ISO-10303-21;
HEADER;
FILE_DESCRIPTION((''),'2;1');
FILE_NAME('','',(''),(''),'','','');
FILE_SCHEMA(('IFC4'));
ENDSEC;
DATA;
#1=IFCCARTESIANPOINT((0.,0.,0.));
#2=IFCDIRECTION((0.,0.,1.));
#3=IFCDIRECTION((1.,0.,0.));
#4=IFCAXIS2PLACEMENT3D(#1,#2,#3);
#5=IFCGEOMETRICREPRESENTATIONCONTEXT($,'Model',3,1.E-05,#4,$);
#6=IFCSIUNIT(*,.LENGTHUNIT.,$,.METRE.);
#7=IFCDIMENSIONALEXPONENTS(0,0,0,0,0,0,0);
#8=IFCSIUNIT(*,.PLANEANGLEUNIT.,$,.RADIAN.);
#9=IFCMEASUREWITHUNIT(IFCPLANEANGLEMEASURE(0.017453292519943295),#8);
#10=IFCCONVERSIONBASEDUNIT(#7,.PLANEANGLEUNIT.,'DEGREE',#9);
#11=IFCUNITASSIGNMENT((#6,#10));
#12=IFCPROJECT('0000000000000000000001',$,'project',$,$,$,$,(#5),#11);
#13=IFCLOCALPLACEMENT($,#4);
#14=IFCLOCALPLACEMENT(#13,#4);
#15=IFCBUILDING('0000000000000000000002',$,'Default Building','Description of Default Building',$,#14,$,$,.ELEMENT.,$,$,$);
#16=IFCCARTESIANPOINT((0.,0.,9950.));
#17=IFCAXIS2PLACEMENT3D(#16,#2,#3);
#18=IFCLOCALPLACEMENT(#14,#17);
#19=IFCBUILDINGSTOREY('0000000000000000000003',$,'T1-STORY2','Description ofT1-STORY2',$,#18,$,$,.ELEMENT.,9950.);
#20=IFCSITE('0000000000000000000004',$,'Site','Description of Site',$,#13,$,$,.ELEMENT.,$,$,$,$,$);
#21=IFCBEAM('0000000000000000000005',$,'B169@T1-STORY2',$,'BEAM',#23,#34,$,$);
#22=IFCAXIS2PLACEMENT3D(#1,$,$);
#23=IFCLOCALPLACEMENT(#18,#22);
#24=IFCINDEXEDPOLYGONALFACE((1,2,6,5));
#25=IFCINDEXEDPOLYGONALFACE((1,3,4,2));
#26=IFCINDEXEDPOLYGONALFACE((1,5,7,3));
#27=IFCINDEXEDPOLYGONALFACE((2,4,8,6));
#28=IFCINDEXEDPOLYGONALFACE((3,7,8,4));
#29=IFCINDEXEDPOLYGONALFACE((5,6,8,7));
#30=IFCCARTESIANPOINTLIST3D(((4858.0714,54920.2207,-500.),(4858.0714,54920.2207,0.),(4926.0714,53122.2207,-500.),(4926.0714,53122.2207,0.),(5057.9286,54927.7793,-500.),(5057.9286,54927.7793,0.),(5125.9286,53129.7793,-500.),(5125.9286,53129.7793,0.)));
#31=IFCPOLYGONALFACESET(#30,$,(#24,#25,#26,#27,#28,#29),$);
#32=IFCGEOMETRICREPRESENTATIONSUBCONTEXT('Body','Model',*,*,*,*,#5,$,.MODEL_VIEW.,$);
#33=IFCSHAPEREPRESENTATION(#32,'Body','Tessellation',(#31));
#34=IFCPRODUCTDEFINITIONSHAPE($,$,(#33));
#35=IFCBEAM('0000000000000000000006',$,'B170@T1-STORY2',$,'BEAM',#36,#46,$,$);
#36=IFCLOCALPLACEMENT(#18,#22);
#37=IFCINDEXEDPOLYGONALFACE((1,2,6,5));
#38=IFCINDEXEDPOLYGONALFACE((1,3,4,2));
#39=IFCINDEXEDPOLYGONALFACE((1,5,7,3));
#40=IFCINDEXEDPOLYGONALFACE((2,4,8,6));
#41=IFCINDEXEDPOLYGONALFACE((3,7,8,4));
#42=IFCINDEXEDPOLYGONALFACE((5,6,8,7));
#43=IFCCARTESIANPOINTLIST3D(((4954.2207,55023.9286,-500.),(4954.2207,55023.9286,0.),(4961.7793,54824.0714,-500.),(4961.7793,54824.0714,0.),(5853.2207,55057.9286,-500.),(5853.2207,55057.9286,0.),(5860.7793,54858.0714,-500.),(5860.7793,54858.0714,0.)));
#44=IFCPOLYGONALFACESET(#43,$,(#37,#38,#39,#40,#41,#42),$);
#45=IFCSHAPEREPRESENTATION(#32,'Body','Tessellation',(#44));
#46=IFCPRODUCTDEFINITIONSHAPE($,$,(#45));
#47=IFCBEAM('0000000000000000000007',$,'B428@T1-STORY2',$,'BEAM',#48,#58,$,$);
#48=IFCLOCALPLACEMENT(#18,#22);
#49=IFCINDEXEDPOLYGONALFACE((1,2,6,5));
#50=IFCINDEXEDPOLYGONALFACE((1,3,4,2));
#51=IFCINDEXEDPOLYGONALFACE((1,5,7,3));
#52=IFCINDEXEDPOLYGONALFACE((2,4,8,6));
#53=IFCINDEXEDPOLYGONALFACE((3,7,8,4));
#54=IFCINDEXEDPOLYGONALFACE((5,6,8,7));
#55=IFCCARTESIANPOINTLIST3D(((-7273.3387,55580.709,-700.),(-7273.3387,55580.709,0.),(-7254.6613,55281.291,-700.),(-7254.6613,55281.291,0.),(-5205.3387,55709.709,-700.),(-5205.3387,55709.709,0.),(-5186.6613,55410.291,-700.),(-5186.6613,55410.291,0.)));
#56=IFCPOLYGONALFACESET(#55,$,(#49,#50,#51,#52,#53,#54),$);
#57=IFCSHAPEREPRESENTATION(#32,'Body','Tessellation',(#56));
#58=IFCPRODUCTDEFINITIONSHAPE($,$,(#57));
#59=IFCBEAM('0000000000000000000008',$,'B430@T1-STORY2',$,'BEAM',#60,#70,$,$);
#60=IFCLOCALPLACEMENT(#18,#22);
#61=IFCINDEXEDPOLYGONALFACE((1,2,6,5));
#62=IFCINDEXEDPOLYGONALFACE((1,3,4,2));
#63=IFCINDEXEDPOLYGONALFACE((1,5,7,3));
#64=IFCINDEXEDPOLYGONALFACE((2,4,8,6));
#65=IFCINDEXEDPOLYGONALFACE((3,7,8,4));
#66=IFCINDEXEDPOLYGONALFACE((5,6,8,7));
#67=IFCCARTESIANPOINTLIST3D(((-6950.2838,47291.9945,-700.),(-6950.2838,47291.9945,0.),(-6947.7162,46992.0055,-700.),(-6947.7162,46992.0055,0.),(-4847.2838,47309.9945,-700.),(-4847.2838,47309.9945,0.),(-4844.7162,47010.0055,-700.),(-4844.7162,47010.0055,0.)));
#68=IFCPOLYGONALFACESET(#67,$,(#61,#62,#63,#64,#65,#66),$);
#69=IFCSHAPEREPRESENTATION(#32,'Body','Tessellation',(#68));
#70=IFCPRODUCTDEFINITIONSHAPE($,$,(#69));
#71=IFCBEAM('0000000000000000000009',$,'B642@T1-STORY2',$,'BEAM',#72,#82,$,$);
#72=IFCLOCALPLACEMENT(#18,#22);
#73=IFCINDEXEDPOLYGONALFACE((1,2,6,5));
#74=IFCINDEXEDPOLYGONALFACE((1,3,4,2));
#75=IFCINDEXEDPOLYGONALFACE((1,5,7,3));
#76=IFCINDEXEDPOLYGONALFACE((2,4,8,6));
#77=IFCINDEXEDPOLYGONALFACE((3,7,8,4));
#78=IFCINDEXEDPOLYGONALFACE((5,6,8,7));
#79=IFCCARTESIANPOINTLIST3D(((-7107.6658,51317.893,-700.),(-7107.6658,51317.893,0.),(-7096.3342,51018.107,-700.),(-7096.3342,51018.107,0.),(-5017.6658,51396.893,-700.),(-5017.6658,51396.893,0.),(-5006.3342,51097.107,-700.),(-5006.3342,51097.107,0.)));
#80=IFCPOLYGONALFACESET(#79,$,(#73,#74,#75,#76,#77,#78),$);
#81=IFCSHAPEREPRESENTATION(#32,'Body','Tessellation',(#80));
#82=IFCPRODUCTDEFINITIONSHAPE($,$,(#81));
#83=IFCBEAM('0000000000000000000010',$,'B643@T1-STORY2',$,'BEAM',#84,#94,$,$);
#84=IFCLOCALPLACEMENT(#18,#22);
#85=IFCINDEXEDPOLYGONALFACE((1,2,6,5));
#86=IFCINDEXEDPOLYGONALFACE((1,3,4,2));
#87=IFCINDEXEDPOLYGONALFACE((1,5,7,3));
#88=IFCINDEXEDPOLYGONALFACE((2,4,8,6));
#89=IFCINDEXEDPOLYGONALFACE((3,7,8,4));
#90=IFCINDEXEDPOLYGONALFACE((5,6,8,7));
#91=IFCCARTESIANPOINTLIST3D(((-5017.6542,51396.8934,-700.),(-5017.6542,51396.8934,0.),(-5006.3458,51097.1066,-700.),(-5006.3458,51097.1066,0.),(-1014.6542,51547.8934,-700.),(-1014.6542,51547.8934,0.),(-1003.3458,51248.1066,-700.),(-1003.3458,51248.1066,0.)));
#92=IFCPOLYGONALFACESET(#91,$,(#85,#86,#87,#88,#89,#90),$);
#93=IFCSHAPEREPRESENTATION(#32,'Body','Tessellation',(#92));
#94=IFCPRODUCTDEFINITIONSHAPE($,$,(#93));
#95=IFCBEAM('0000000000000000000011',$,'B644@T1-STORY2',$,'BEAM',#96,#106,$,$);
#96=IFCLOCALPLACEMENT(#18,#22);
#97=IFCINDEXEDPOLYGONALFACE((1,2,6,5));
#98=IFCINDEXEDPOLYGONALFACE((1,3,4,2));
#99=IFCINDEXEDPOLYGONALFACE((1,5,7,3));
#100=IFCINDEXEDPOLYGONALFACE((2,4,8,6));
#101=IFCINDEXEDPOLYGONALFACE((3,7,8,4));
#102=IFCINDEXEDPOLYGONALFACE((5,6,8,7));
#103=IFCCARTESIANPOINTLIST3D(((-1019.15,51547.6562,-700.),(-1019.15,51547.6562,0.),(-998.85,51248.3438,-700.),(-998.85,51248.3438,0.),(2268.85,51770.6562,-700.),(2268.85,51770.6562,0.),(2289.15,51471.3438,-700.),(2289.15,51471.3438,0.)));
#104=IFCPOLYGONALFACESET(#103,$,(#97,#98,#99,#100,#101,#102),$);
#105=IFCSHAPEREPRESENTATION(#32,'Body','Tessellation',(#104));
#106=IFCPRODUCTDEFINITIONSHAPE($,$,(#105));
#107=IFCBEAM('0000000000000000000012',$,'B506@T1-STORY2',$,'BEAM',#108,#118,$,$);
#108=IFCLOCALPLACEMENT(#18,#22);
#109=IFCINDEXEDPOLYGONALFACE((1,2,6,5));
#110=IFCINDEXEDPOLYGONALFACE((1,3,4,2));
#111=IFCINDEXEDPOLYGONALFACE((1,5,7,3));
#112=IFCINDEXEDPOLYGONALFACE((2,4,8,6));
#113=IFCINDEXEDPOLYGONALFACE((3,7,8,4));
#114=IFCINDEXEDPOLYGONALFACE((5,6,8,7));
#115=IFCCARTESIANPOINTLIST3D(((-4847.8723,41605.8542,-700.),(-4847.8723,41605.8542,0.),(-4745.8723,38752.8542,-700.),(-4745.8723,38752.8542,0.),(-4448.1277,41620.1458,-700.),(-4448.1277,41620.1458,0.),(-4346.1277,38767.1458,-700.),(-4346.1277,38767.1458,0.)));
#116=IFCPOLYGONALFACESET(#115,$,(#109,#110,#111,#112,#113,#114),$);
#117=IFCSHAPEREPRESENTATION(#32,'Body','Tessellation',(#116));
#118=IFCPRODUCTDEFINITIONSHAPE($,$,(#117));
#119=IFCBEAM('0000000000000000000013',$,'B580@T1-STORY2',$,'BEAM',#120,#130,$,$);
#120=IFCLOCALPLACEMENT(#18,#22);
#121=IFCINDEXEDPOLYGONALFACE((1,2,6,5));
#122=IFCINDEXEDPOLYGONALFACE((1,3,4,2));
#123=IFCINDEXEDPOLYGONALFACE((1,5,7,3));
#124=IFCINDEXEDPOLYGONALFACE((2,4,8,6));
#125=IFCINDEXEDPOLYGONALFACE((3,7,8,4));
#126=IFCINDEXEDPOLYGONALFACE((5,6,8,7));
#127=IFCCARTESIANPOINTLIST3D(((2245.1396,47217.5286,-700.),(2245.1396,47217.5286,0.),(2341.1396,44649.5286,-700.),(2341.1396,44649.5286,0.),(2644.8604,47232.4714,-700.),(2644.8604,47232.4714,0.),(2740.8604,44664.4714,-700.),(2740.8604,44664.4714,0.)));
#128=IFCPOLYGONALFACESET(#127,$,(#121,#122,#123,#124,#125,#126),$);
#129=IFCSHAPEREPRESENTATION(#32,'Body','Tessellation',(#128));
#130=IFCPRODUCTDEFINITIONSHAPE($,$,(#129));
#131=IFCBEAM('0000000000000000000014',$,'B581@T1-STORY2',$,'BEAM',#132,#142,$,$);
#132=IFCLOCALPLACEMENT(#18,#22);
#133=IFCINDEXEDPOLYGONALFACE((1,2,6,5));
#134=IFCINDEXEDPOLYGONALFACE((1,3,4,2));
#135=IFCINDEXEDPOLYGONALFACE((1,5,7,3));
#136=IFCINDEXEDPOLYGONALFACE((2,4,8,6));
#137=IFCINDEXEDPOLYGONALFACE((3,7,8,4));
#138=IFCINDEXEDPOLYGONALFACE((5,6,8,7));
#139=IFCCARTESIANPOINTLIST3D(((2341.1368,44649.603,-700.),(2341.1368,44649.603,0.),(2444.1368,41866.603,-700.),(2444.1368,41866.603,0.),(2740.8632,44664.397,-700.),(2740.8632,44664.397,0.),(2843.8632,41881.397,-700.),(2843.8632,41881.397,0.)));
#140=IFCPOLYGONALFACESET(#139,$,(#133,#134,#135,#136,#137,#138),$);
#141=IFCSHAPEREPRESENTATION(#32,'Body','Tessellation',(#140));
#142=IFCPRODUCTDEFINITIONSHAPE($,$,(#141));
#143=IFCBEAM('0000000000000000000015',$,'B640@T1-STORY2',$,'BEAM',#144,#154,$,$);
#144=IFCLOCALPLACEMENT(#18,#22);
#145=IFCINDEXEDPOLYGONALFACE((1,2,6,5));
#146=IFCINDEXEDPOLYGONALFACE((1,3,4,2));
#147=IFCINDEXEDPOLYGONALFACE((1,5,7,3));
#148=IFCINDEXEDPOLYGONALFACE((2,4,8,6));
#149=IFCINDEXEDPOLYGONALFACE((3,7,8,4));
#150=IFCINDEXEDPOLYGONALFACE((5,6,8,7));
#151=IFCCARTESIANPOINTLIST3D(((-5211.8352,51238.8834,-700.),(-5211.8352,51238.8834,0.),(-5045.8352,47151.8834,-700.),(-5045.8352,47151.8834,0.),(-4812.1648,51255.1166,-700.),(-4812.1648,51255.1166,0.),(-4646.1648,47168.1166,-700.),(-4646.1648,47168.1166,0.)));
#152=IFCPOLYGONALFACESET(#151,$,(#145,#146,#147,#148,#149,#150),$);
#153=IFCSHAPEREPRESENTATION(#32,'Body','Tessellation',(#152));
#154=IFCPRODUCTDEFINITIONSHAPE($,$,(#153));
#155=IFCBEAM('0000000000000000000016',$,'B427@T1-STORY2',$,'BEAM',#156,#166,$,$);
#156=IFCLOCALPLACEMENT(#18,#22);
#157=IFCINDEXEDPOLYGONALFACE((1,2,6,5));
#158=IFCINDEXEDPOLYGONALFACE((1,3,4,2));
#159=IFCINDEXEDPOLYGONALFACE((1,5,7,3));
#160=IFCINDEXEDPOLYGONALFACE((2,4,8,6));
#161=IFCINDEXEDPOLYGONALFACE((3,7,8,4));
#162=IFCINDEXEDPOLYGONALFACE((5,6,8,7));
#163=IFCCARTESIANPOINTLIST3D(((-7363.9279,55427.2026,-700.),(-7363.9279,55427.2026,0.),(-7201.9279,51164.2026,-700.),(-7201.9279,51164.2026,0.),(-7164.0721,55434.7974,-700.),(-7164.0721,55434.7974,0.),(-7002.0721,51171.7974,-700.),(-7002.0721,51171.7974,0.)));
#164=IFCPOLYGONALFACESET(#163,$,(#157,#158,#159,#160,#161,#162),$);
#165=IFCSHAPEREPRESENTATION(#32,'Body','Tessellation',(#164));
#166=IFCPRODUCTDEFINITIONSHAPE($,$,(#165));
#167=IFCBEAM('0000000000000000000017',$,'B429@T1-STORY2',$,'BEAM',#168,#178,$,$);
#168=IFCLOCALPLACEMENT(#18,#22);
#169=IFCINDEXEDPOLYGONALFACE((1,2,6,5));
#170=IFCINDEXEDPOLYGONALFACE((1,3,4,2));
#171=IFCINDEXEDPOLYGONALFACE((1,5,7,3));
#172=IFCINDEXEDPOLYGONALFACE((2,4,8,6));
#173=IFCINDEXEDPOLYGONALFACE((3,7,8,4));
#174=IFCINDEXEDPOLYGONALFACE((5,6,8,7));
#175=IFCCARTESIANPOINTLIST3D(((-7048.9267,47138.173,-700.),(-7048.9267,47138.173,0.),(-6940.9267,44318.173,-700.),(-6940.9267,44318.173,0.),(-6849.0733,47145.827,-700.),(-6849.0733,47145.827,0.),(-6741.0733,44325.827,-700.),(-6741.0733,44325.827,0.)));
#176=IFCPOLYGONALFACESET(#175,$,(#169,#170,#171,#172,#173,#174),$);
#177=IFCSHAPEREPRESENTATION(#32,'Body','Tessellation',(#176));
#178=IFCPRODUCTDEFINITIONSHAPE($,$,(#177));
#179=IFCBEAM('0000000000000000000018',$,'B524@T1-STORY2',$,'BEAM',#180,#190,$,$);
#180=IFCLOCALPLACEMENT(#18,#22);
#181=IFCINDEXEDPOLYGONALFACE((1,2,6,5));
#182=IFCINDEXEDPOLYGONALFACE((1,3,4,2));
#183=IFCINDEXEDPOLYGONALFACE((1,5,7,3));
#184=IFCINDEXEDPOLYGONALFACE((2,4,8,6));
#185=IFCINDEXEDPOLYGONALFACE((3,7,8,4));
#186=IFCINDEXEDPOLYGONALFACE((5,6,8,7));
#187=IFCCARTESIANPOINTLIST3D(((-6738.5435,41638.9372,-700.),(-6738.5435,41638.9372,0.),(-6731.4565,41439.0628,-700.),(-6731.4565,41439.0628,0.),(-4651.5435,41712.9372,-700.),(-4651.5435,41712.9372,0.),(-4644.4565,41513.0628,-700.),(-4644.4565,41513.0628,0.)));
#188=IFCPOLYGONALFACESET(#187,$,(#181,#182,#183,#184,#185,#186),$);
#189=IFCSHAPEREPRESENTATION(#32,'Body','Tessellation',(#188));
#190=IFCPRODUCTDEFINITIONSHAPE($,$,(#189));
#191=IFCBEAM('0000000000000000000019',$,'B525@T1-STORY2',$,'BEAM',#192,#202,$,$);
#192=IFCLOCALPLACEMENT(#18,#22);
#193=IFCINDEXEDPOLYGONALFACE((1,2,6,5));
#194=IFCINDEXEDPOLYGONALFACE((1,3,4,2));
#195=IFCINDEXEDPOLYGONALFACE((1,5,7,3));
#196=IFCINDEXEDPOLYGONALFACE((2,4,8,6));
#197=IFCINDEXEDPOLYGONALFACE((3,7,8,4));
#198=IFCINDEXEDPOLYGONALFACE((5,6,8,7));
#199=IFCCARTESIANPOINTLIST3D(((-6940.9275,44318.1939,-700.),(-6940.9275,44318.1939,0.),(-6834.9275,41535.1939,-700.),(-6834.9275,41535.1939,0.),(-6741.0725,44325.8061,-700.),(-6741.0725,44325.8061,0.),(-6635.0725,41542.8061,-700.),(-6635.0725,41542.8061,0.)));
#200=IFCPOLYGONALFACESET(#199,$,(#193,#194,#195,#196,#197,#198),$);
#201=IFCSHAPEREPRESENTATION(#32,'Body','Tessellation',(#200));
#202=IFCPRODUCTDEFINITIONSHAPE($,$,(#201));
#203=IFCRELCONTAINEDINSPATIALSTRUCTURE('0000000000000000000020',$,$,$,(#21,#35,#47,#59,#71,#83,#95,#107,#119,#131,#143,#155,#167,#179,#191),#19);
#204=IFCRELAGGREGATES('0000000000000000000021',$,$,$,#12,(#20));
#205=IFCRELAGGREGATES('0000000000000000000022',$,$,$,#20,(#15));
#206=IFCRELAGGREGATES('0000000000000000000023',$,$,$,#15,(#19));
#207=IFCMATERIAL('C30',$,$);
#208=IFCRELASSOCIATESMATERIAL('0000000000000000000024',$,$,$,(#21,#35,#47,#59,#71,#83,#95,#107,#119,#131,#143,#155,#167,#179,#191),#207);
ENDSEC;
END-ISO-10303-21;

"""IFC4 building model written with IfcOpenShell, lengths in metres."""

from ifc_helpers import new_model, entity, si_unit, converted_unit, frame, origin_with_axes, place, context, subcontext, project, spatial, rectangle, extrude, material, element, save


model = new_model("IFC4")

# Units and contexts
model_context = context("Model", 3, precision=1e-05, world=origin_with_axes())
body_context = subcontext(model_context, "Body", "Model", "MODEL_VIEW")
ifc_project = project(units=[si_unit("LENGTHUNIT", "METRE"), converted_unit("PLANEANGLEUNIT", "DEGREE", entity("IfcPlaneAngleMeasure", 0.017453292519943295), si_unit("PLANEANGLEUNIT", "RADIAN"), dimensions=[0, 0, 0, 0, 0, 0, 0])], contexts=[model_context])

# Site, building, storey
site_placement = place(None, origin_with_axes())
site = spatial("IfcSite", under=ifc_project, at=site_placement, Name="Site", Description="Description of Site", CompositionType="ELEMENT")
building_placement = place(site_placement, origin_with_axes())
building = spatial("IfcBuilding", under=site, at=building_placement, Name="Default Building", Description="Description of Default Building", CompositionType="ELEMENT")
storey_placement = place(building_placement, frame((0.0, 0.0, 9950.0), z_axis=(0.0, 0.0, 1.0), x_axis=(1.0, 0.0, 0.0)))
storey = spatial("IfcBuildingStorey", under=building, at=storey_placement, Name="T1-STORY2", Description="Description ofT1-STORY2", CompositionType="ELEMENT", Elevation=9950.0)

# Beams
ifc_material_1 = material(Name="C30")
beam_1_placement = place(storey_placement, frame((4958.0, 54924.0, -250.0), z_axis=(0.037793, -0.999286, 0.0), x_axis=(0.999286, 0.037793, 0.0)))
element("IfcBeam", 1, at=beam_1_placement, inside=storey, material=ifc_material_1, Name="B169@T1-STORY2", ObjectType="BEAM", context=body_context, shape_type="SweptSolid", body=[
    extrude(rectangle(XDim=200.0, YDim=500.0), origin_with_axes(), (0.0, 0.0, 1.0), 1799.2854),
])
beam_2_placement = place(storey_placement, frame((4958.0, 54924.0, -250.0), z_axis=(0.999286, 0.037793, 0.0), x_axis=(-0.037793, 0.999286, 0.0)))
element("IfcBeam", 2, at=beam_2_placement, inside=storey, material=ifc_material_1, Name="B170@T1-STORY2", ObjectType="BEAM", context=body_context, shape_type="SweptSolid", body=[
    extrude(rectangle(XDim=200.0, YDim=500.0), origin_with_axes(), (0.0, 0.0, 1.0), 899.6427),
])
beam_3_placement = place(storey_placement, frame((-7264.0, 55431.0, -350.0), z_axis=(0.99806, 0.062258, 0.0), x_axis=(-0.062258, 0.99806, 0.0)))
element("IfcBeam", 3, at=beam_3_placement, inside=storey, material=ifc_material_1, Name="B428@T1-STORY2", ObjectType="BEAM", context=body_context, shape_type="SweptSolid", body=[
    extrude(rectangle(XDim=300.0, YDim=700.0), origin_with_axes(), (0.0, 0.0, 1.0), 2072.0195),
])
beam_4_placement = place(storey_placement, frame((-6949.0, 47142.0, -350.0), z_axis=(0.999963, 0.008559, 0.0), x_axis=(-0.008559, 0.999963, 0.0)))
element("IfcBeam", 4, at=beam_4_placement, inside=storey, material=ifc_material_1, Name="B430@T1-STORY2", ObjectType="BEAM", context=body_context, shape_type="SweptSolid", body=[
    extrude(rectangle(XDim=300.0, YDim=700.0), origin_with_axes(), (0.0, 0.0, 1.0), 2103.077),
])
beam_5_placement = place(storey_placement, frame((-7102.0, 51168.0, -350.0), z_axis=(0.999286, 0.037772, 0.0), x_axis=(-0.037772, 0.999286, 0.0)))
element("IfcBeam", 5, at=beam_5_placement, inside=storey, material=ifc_material_1, Name="B642@T1-STORY2", ObjectType="BEAM", context=body_context, shape_type="SweptSolid", body=[
    extrude(rectangle(XDim=300.0, YDim=700.0), origin_with_axes(), (0.0, 0.0, 1.0), 2091.4925),
])
beam_6_placement = place(storey_placement, frame((-5012.0, 51247.0, -350.0), z_axis=(0.999289, 0.037695, 0.0), x_axis=(-0.037695, 0.999289, 0.0)))
element("IfcBeam", 6, at=beam_6_placement, inside=storey, material=ifc_material_1, Name="B643@T1-STORY2", ObjectType="BEAM", context=body_context, shape_type="SweptSolid", body=[
    extrude(rectangle(XDim=300.0, YDim=700.0), origin_with_axes(), (0.0, 0.0, 1.0), 4005.847),
])
beam_7_placement = place(storey_placement, frame((-1009.0, 51398.0, -350.0), z_axis=(0.997708, 0.067667, 0.0), x_axis=(-0.067667, 0.997708, 0.0)))
element("IfcBeam", 7, at=beam_7_placement, inside=storey, material=ifc_material_1, Name="B644@T1-STORY2", ObjectType="BEAM", context=body_context, shape_type="SweptSolid", body=[
    extrude(rectangle(XDim=300.0, YDim=700.0), origin_with_axes(), (0.0, 0.0, 1.0), 3295.5535),
])
beam_8_placement = place(storey_placement, frame((-4648.0, 41613.0, -350.0), z_axis=(0.035729, -0.999362, 0.0), x_axis=(0.999362, 0.035729, 0.0)))
element("IfcBeam", 8, at=beam_8_placement, inside=storey, material=ifc_material_1, Name="B506@T1-STORY2", ObjectType="BEAM", context=body_context, shape_type="SweptSolid", body=[
    extrude(rectangle(XDim=400.0, YDim=700.0), origin_with_axes(), (0.0, 0.0, 1.0), 2854.8228),
])
beam_9_placement = place(storey_placement, frame((2445.0, 47225.0, -350.0), z_axis=(0.037357, -0.999302, 0.0), x_axis=(0.999302, 0.037357, 0.0)))
element("IfcBeam", 9, at=beam_9_placement, inside=storey, material=ifc_material_1, Name="B580@T1-STORY2", ObjectType="BEAM", context=body_context, shape_type="SweptSolid", body=[
    extrude(rectangle(XDim=400.0, YDim=700.0), origin_with_axes(), (0.0, 0.0, 1.0), 2569.7938),
])
beam_10_placement = place(storey_placement, frame((2541.0, 44657.0, -350.0), z_axis=(0.036985, -0.999316, 0.0), x_axis=(0.999316, 0.036985, 0.0)))
element("IfcBeam", 10, at=beam_10_placement, inside=storey, material=ifc_material_1, Name="B581@T1-STORY2", ObjectType="BEAM", context=body_context, shape_type="SweptSolid", body=[
    extrude(rectangle(XDim=400.0, YDim=700.0), origin_with_axes(), (0.0, 0.0, 1.0), 2784.9054),
])
beam_11_placement = place(storey_placement, frame((-5012.0, 51247.0, -350.0), z_axis=(0.040583, -0.999176, 0.0), x_axis=(0.999176, 0.040583, 0.0)))
element("IfcBeam", 11, at=beam_11_placement, inside=storey, material=ifc_material_1, Name="B640@T1-STORY2", ObjectType="BEAM", context=body_context, shape_type="SweptSolid", body=[
    extrude(rectangle(XDim=400.0, YDim=700.0), origin_with_axes(), (0.0, 0.0, 1.0), 4090.3698),
])
beam_12_placement = place(storey_placement, frame((-7264.0, 55431.0, -350.0), z_axis=(0.037974, -0.999279, 0.0), x_axis=(0.999279, 0.037974, 0.0)))
element("IfcBeam", 12, at=beam_12_placement, inside=storey, material=ifc_material_1, Name="B427@T1-STORY2", ObjectType="BEAM", context=body_context, shape_type="SweptSolid", body=[
    extrude(rectangle(XDim=200.0, YDim=700.0), origin_with_axes(), (0.0, 0.0, 1.0), 4266.077),
])
beam_13_placement = place(storey_placement, frame((-6949.0, 47142.0, -350.0), z_axis=(0.03827, -0.999267, 0.0), x_axis=(0.999267, 0.03827, 0.0)))
element("IfcBeam", 13, at=beam_13_placement, inside=storey, material=ifc_material_1, Name="B429@T1-STORY2", ObjectType="BEAM", context=body_context, shape_type="SweptSolid", body=[
    extrude(rectangle(XDim=200.0, YDim=700.0), origin_with_axes(), (0.0, 0.0, 1.0), 2822.0673),
])
beam_14_placement = place(storey_placement, frame((-6735.0, 41539.0, -350.0), z_axis=(0.999372, 0.035435, 0.0), x_axis=(-0.035435, 0.999372, 0.0)))
element("IfcBeam", 14, at=beam_14_placement, inside=storey, material=ifc_material_1, Name="B524@T1-STORY2", ObjectType="BEAM", context=body_context, shape_type="SweptSolid", body=[
    extrude(rectangle(XDim=200.0, YDim=700.0), origin_with_axes(), (0.0, 0.0, 1.0), 2088.3115),
])
beam_15_placement = place(storey_placement, frame((-6841.0, 44322.0, -350.0), z_axis=(0.038061, -0.999275, 0.0), x_axis=(0.999275, 0.038061, 0.0)))
element("IfcBeam", 15, at=beam_15_placement, inside=storey, material=ifc_material_1, Name="B525@T1-STORY2", ObjectType="BEAM", context=body_context, shape_type="SweptSolid", body=[
    extrude(rectangle(XDim=200.0, YDim=700.0), origin_with_axes(), (0.0, 0.0, 1.0), 2785.018),
])

save(model, "model.ifc")
